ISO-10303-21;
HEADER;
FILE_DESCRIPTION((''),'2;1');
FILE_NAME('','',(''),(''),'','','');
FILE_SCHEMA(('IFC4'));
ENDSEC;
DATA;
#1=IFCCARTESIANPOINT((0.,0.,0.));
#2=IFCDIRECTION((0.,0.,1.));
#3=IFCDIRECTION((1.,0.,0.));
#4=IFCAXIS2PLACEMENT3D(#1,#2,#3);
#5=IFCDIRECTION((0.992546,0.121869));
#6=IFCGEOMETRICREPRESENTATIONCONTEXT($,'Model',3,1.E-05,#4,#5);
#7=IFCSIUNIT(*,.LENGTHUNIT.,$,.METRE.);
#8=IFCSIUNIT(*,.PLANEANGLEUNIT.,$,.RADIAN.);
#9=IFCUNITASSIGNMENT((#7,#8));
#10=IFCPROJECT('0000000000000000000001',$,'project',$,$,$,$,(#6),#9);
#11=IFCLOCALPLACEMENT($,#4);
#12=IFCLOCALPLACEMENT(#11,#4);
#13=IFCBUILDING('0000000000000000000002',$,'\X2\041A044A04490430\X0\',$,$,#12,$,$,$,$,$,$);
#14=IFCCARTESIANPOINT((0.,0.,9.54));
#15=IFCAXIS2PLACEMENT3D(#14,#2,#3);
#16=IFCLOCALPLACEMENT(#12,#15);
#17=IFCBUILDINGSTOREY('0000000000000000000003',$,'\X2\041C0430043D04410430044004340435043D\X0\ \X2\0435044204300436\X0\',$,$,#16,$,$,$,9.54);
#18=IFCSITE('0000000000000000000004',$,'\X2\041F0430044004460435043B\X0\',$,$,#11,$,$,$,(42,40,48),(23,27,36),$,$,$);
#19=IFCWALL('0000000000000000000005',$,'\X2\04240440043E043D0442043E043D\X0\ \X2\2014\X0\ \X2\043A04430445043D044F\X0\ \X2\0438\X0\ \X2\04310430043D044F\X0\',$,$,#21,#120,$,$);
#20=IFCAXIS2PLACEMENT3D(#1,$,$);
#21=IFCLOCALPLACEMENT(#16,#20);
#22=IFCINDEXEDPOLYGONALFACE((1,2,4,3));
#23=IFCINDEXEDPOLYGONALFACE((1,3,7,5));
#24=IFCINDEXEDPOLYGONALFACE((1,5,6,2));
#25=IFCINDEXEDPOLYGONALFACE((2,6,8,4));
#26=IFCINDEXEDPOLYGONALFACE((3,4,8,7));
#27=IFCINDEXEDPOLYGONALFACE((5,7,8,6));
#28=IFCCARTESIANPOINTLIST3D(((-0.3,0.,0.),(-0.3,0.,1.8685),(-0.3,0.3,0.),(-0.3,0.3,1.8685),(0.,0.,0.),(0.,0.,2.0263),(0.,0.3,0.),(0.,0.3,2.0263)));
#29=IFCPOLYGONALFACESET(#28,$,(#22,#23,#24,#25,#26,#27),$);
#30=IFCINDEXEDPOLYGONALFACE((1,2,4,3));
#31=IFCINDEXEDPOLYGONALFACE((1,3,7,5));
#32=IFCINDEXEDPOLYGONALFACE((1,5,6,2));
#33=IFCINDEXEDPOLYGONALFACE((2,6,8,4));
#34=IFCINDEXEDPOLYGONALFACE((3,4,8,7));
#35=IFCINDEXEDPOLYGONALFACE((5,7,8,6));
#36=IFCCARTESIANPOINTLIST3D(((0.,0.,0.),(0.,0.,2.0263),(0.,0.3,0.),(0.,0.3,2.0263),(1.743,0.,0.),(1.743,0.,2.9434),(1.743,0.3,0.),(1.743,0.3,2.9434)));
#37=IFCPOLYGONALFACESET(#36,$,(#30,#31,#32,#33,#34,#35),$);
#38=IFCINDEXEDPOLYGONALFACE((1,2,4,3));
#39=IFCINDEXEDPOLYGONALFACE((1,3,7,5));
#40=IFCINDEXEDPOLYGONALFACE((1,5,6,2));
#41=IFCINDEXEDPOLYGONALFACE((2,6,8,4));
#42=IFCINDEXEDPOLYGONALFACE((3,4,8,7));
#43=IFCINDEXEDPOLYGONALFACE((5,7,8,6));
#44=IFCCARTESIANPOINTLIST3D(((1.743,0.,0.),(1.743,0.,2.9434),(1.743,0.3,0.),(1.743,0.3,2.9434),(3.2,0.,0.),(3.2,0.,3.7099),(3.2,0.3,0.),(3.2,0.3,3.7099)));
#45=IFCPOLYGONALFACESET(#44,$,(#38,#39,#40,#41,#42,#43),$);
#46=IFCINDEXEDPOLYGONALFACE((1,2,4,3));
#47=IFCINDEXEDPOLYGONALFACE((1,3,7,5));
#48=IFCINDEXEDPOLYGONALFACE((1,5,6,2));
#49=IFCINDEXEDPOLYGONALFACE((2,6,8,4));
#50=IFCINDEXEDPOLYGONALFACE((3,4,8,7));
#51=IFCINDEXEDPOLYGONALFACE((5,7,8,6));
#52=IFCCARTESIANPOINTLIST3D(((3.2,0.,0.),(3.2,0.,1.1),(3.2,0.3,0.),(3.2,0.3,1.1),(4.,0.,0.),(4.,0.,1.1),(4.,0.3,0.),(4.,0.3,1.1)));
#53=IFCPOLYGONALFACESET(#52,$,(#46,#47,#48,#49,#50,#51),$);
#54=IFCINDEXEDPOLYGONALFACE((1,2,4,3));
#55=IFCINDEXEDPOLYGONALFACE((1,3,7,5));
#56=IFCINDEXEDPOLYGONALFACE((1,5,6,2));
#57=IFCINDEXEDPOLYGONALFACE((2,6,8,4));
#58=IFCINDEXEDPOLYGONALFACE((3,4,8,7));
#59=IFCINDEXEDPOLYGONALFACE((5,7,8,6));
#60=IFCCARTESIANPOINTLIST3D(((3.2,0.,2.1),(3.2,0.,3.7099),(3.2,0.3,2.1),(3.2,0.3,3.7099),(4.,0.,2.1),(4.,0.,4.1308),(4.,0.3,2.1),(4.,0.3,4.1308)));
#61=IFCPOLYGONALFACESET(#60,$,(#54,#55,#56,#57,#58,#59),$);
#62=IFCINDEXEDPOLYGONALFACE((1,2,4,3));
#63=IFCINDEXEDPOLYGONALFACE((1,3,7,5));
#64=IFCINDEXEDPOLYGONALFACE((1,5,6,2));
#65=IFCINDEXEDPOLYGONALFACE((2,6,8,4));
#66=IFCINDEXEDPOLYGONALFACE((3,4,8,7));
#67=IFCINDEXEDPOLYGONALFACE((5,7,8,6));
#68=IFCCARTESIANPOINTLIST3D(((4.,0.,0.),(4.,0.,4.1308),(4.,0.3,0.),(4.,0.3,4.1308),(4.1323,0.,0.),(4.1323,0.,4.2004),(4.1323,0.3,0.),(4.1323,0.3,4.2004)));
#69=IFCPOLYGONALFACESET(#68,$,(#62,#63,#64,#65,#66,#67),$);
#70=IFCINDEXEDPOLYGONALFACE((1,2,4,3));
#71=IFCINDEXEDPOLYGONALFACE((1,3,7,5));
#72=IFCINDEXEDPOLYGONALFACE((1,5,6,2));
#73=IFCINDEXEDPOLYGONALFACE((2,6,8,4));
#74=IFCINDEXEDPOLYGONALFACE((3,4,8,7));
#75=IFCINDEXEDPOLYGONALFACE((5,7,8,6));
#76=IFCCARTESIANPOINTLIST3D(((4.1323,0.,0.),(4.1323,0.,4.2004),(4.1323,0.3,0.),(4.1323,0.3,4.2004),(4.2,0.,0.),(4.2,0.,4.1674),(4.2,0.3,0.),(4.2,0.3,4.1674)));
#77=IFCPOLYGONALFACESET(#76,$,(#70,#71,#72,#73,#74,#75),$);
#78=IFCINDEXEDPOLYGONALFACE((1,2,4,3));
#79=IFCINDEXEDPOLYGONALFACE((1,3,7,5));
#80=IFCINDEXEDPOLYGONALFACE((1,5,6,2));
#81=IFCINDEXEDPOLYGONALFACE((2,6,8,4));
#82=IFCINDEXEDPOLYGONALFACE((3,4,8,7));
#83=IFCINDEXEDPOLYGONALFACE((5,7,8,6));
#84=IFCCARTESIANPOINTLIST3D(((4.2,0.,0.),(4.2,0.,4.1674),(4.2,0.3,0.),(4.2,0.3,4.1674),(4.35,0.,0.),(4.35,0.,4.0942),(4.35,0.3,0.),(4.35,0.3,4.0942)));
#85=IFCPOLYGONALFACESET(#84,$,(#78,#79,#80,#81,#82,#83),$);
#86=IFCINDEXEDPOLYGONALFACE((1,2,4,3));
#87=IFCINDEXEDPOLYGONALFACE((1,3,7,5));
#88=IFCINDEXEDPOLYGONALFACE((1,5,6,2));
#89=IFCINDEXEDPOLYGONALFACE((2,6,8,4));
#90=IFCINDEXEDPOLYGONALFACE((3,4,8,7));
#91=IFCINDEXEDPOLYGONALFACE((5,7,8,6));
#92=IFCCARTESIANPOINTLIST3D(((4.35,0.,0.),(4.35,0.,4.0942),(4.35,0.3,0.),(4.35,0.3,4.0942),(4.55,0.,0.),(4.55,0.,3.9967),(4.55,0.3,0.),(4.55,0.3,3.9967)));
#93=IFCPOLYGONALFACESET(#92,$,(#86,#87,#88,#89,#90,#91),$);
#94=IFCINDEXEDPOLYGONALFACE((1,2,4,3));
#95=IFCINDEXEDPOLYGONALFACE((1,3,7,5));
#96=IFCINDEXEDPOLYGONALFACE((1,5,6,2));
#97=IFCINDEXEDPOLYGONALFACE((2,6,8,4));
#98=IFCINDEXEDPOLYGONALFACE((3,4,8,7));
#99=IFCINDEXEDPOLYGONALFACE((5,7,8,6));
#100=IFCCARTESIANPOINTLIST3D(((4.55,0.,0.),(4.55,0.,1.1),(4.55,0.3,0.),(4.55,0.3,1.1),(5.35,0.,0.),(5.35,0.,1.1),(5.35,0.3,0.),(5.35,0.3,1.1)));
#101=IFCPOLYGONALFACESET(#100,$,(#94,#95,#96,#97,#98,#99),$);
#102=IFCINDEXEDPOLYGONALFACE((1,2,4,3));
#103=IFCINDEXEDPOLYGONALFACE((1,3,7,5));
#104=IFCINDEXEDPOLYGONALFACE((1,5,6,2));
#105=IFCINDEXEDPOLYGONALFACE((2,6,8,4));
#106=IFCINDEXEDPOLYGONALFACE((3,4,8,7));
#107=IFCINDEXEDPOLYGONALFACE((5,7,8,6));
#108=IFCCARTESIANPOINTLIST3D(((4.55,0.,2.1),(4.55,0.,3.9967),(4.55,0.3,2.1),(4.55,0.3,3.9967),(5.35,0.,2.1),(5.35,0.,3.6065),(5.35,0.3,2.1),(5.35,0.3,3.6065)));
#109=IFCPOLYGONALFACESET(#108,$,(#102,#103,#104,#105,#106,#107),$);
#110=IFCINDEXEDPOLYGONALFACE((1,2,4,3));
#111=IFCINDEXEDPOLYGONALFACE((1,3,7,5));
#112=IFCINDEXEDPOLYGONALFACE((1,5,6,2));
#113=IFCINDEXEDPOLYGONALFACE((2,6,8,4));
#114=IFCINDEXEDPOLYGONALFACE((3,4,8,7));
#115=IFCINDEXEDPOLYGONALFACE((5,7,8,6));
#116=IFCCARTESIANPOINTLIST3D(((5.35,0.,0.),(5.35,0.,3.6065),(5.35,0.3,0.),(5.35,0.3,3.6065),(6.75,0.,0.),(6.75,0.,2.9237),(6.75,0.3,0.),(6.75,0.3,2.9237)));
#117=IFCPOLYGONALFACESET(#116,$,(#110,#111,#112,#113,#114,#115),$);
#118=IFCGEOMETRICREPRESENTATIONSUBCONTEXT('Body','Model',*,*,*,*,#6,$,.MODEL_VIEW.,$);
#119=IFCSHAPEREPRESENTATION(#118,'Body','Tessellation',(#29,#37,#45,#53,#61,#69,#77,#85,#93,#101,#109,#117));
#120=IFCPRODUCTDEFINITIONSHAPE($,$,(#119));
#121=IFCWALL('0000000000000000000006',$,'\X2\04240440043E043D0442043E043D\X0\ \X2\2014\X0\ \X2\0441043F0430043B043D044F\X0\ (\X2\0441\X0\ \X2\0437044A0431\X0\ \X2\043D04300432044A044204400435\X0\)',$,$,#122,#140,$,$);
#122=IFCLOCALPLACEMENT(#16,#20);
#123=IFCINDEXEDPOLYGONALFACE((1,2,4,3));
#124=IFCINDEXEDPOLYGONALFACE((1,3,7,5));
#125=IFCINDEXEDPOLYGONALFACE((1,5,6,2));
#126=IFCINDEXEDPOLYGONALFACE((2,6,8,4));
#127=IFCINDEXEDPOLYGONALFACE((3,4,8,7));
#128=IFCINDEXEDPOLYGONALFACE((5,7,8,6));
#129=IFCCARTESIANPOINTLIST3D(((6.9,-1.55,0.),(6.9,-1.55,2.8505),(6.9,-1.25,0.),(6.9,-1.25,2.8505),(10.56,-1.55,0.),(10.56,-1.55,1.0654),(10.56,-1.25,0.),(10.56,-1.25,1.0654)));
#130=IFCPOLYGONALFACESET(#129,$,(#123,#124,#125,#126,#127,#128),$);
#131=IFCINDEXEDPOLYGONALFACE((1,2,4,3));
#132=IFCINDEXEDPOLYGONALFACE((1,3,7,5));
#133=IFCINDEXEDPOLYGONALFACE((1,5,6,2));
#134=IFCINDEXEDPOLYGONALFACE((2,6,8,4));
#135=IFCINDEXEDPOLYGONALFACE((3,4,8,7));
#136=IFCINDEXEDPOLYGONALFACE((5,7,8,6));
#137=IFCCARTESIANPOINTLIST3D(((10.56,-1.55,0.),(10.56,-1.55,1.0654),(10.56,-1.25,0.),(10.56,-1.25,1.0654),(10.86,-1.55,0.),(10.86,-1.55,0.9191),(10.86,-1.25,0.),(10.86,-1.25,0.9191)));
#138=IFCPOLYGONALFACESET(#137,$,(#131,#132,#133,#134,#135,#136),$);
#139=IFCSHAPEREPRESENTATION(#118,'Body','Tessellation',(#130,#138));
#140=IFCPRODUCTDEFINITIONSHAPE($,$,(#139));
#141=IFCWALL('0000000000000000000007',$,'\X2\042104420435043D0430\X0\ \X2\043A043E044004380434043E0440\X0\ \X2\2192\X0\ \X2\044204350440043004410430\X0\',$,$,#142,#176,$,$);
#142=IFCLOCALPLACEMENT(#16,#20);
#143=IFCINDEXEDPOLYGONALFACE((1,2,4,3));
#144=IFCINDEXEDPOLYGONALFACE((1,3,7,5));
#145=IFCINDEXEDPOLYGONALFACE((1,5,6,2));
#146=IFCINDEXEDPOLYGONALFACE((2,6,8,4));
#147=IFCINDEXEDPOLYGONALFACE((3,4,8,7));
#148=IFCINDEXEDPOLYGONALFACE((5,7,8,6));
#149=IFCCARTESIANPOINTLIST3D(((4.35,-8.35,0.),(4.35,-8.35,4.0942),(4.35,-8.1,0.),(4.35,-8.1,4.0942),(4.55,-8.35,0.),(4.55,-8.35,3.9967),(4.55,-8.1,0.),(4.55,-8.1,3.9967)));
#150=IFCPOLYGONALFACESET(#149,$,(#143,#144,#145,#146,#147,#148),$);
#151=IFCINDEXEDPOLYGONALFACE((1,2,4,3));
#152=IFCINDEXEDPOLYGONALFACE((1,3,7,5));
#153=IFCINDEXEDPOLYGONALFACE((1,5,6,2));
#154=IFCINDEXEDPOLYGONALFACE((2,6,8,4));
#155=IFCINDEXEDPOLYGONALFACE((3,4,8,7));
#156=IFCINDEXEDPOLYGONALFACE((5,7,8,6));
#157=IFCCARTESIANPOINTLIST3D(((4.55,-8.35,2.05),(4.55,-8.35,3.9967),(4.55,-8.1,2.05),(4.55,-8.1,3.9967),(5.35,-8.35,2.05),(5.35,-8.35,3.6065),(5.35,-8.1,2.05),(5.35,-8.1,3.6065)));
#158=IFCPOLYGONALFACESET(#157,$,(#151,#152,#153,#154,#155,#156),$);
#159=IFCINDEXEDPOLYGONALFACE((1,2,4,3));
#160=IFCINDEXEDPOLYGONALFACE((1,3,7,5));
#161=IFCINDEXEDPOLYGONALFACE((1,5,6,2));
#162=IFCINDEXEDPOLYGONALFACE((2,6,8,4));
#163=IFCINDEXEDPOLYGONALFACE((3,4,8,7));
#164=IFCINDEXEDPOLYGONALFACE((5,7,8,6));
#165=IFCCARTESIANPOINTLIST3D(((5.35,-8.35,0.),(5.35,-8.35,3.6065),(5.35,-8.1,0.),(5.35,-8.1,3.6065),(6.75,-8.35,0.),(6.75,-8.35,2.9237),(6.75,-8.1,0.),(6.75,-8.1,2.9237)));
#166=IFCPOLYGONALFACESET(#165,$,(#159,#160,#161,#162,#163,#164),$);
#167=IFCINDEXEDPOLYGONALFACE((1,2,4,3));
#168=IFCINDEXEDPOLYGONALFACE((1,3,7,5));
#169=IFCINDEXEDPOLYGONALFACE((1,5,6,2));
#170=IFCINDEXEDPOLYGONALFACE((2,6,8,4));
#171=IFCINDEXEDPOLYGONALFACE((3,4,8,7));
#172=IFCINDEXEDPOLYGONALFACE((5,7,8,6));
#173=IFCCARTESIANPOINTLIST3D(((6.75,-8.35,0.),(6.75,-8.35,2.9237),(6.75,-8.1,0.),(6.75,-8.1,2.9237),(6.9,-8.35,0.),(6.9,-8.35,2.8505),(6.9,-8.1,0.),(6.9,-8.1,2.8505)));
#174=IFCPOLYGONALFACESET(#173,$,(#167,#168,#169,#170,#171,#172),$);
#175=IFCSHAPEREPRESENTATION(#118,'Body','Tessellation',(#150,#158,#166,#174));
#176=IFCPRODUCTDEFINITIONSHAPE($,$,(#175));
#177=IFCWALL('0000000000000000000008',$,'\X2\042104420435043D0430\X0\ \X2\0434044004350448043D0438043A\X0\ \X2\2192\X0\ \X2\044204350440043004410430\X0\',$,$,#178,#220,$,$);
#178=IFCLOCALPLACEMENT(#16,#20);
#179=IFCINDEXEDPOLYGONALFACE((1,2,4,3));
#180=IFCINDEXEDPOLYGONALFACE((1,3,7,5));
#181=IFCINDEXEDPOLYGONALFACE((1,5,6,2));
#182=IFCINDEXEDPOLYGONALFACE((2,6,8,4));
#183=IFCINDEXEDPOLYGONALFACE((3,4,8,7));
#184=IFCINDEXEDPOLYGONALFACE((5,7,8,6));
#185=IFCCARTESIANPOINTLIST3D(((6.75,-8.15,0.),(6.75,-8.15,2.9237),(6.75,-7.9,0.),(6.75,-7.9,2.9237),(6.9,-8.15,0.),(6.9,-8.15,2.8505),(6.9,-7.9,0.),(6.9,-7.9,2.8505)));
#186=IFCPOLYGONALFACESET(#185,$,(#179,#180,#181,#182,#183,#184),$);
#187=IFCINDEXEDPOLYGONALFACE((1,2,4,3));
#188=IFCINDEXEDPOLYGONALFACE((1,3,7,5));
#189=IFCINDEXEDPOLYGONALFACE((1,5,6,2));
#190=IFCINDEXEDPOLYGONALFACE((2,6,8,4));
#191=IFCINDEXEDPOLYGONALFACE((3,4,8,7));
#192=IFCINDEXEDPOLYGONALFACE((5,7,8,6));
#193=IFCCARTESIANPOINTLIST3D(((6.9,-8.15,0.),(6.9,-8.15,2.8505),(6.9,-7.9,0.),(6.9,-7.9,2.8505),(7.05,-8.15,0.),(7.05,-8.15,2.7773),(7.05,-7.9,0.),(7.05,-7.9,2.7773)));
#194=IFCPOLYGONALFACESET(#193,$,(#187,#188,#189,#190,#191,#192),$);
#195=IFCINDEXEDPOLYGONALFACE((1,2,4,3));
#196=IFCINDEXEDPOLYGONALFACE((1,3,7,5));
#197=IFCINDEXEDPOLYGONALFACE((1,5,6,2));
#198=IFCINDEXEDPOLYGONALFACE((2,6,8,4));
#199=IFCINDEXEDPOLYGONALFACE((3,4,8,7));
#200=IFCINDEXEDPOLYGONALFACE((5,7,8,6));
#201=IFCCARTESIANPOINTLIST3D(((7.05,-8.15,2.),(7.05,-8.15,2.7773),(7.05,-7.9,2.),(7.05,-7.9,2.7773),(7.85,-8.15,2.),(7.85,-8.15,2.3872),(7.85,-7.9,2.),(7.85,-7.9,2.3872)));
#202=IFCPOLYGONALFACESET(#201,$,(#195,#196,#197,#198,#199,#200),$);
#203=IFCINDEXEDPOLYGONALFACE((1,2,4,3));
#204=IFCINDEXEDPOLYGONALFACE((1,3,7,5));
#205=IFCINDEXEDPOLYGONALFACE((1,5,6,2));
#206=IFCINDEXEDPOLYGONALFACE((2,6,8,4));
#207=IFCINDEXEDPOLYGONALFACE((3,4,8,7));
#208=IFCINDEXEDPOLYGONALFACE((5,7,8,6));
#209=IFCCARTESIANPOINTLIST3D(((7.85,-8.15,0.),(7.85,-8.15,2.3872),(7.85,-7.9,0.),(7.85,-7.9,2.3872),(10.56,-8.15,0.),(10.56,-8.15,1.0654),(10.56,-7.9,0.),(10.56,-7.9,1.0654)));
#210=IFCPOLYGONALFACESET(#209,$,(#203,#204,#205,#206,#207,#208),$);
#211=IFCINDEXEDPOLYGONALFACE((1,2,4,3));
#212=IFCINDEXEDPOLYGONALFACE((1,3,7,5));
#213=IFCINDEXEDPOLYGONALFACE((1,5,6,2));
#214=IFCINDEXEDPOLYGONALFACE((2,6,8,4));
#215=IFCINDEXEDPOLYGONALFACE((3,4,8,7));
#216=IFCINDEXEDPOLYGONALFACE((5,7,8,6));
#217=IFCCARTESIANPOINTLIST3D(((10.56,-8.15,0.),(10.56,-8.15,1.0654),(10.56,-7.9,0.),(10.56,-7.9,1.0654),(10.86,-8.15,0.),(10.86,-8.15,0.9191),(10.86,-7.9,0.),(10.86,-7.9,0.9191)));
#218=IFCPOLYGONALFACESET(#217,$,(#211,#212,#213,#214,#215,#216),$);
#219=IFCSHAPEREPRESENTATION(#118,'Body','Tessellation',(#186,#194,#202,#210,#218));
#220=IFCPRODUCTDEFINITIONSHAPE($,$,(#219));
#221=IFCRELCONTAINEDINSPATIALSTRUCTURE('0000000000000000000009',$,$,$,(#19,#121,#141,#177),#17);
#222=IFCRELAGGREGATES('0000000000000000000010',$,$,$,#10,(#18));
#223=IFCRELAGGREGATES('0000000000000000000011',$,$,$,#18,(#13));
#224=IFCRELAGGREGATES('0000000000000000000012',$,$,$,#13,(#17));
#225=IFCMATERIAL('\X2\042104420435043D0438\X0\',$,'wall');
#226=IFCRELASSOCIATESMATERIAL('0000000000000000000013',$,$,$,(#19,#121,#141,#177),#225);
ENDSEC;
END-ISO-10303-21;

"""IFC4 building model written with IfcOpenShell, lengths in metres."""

from ifc_helpers import new_model, si_unit, direction, frame, origin_with_axes, place, context, subcontext, project, spatial, polyline, outline, extrude, material, element, save


model = new_model("IFC4")

# Units and contexts
model_context = context("Model", 3, precision=1e-05, world=origin_with_axes(), true_north=direction((0.992546, 0.121869)))
body_context = subcontext(model_context, "Body", "Model", "MODEL_VIEW")
ifc_project = project(units=[si_unit("LENGTHUNIT", "METRE"), si_unit("PLANEANGLEUNIT", "RADIAN")], contexts=[model_context])

# Site, building, storey
site_placement = place(None, origin_with_axes())
site = spatial("IfcSite", under=ifc_project, at=site_placement, Name="Парцел", RefLatitude=(42, 40, 48), RefLongitude=(23, 27, 36))
building_placement = place(site_placement, origin_with_axes())
building = spatial("IfcBuilding", under=site, at=building_placement, Name="Къща")
storey_placement = place(building_placement, frame((0.0, 0.0, 9.54), z_axis=(0.0, 0.0, 1.0), x_axis=(1.0, 0.0, 0.0)))
storey = spatial("IfcBuildingStorey", under=building, at=storey_placement, Name="Мансарден етаж", Elevation=9.54)

# Walls
ifc_material_1 = material(Name="Стени", Category="wall")
wall_1_placement = place(storey_placement, origin_with_axes())
element("IfcWall", 1, at=wall_1_placement, inside=storey, material=ifc_material_1, Name="Фронтон — кухня и баня", context=body_context, shape_type="SweptSolid", body=[
    extrude(outline(polyline([(-0.3, 0.0), (0.0, 0.0), (0.0, -2.0263), (-0.3, -1.8685), (-0.3, 0.0)])), frame((0.0, 0.0, 0.0), z_axis=(0.0, 1.0, 0.0), x_axis=(1.0, 0.0, 0.0)), (0.0, 0.0, 1.0), 0.3),
    extrude(outline(polyline([(0.0, 0.0), (1.743, 0.0), (1.743, -2.9434), (0.0, -2.0263), (0.0, 0.0)])), frame((0.0, 0.0, 0.0), z_axis=(0.0, 1.0, 0.0), x_axis=(1.0, 0.0, 0.0)), (0.0, 0.0, 1.0), 0.3),
    extrude(outline(polyline([(1.743, 0.0), (3.2, 0.0), (3.2, -3.7099), (1.743, -2.9434), (1.743, 0.0)])), frame((0.0, 0.0, 0.0), z_axis=(0.0, 1.0, 0.0), x_axis=(1.0, 0.0, 0.0)), (0.0, 0.0, 1.0), 0.3),
    extrude(outline(polyline([(3.2, 0.0), (4.0, 0.0), (4.0, -1.1), (3.2, -1.1), (3.2, 0.0)])), frame((0.0, 0.0, 0.0), z_axis=(0.0, 1.0, 0.0), x_axis=(1.0, 0.0, 0.0)), (0.0, 0.0, 1.0), 0.3),
    extrude(outline(polyline([(3.2, -2.1), (4.0, -2.1), (4.0, -4.1308), (3.2, -3.7099), (3.2, -2.1)])), frame((0.0, 0.0, 0.0), z_axis=(0.0, 1.0, 0.0), x_axis=(1.0, 0.0, 0.0)), (0.0, 0.0, 1.0), 0.3),
    extrude(outline(polyline([(4.0, 0.0), (4.1323, 0.0), (4.1323, -4.2004), (4.0, -4.1308), (4.0, 0.0)])), frame((0.0, 0.0, 0.0), z_axis=(0.0, 1.0, 0.0), x_axis=(1.0, 0.0, 0.0)), (0.0, 0.0, 1.0), 0.3),
    extrude(outline(polyline([(4.1323, 0.0), (4.2, 0.0), (4.2, -4.1674), (4.1323, -4.2004), (4.1323, 0.0)])), frame((0.0, 0.0, 0.0), z_axis=(0.0, 1.0, 0.0), x_axis=(1.0, 0.0, 0.0)), (0.0, 0.0, 1.0), 0.3),
    extrude(outline(polyline([(4.2, 0.0), (4.35, 0.0), (4.35, -4.0942), (4.2, -4.1674), (4.2, 0.0)])), frame((0.0, 0.0, 0.0), z_axis=(0.0, 1.0, 0.0), x_axis=(1.0, 0.0, 0.0)), (0.0, 0.0, 1.0), 0.3),
    extrude(outline(polyline([(4.35, 0.0), (4.55, 0.0), (4.55, -3.9967), (4.35, -4.0942), (4.35, 0.0)])), frame((0.0, 0.0, 0.0), z_axis=(0.0, 1.0, 0.0), x_axis=(1.0, 0.0, 0.0)), (0.0, 0.0, 1.0), 0.3),
    extrude(outline(polyline([(4.55, 0.0), (5.35, 0.0), (5.35, -1.1), (4.55, -1.1), (4.55, 0.0)])), frame((0.0, 0.0, 0.0), z_axis=(0.0, 1.0, 0.0), x_axis=(1.0, 0.0, 0.0)), (0.0, 0.0, 1.0), 0.3),
    extrude(outline(polyline([(4.55, -2.1), (5.35, -2.1), (5.35, -3.6065), (4.55, -3.9967), (4.55, -2.1)])), frame((0.0, 0.0, 0.0), z_axis=(0.0, 1.0, 0.0), x_axis=(1.0, 0.0, 0.0)), (0.0, 0.0, 1.0), 0.3),
    extrude(outline(polyline([(5.35, 0.0), (6.75, 0.0), (6.75, -2.9237), (5.35, -3.6065), (5.35, 0.0)])), frame((0.0, 0.0, 0.0), z_axis=(0.0, 1.0, 0.0), x_axis=(1.0, 0.0, 0.0)), (0.0, 0.0, 1.0), 0.3),
])
wall_2_placement = place(storey_placement, origin_with_axes())
element("IfcWall", 2, at=wall_2_placement, inside=storey, material=ifc_material_1, Name="Фронтон — спалня (с зъб навътре)", context=body_context, shape_type="SweptSolid", body=[
    extrude(outline(polyline([(6.9, 0.0), (10.56, 0.0), (10.56, -1.0654), (6.9, -2.8505), (6.9, 0.0)])), frame((0.0, -1.55, 0.0), z_axis=(0.0, 1.0, 0.0), x_axis=(1.0, 0.0, 0.0)), (0.0, 0.0, 1.0), 0.3),
    extrude(outline(polyline([(10.56, 0.0), (10.86, 0.0), (10.86, -0.9191), (10.56, -1.0654), (10.56, 0.0)])), frame((0.0, -1.55, 0.0), z_axis=(0.0, 1.0, 0.0), x_axis=(1.0, 0.0, 0.0)), (0.0, 0.0, 1.0), 0.3),
])
wall_3_placement = place(storey_placement, origin_with_axes())
element("IfcWall", 3, at=wall_3_placement, inside=storey, material=ifc_material_1, Name="Стена коридор → тераса", context=body_context, shape_type="SweptSolid", body=[
    extrude(outline(polyline([(4.35, 0.0), (4.55, 0.0), (4.55, -3.9967), (4.35, -4.0942), (4.35, 0.0)])), frame((0.0, -8.35, 0.0), z_axis=(0.0, 1.0, 0.0), x_axis=(1.0, 0.0, 0.0)), (0.0, 0.0, 1.0), 0.25),
    extrude(outline(polyline([(4.55, -2.05), (5.35, -2.05), (5.35, -3.6065), (4.55, -3.9967), (4.55, -2.05)])), frame((0.0, -8.35, 0.0), z_axis=(0.0, 1.0, 0.0), x_axis=(1.0, 0.0, 0.0)), (0.0, 0.0, 1.0), 0.25),
    extrude(outline(polyline([(5.35, 0.0), (6.75, 0.0), (6.75, -2.9237), (5.35, -3.6065), (5.35, 0.0)])), frame((0.0, -8.35, 0.0), z_axis=(0.0, 1.0, 0.0), x_axis=(1.0, 0.0, 0.0)), (0.0, 0.0, 1.0), 0.25),
    extrude(outline(polyline([(6.75, 0.0), (6.9, 0.0), (6.9, -2.8505), (6.75, -2.9237), (6.75, 0.0)])), frame((0.0, -8.35, 0.0), z_axis=(0.0, 1.0, 0.0), x_axis=(1.0, 0.0, 0.0)), (0.0, 0.0, 1.0), 0.25),
])
wall_4_placement = place(storey_placement, origin_with_axes())
element("IfcWall", 4, at=wall_4_placement, inside=storey, material=ifc_material_1, Name="Стена дрешник → тераса", context=body_context, shape_type="SweptSolid", body=[
    extrude(outline(polyline([(6.75, 0.0), (6.9, 0.0), (6.9, -2.8505), (6.75, -2.9237), (6.75, 0.0)])), frame((0.0, -8.15, 0.0), z_axis=(0.0, 1.0, 0.0), x_axis=(1.0, 0.0, 0.0)), (0.0, 0.0, 1.0), 0.25),
    extrude(outline(polyline([(6.9, 0.0), (7.05, 0.0), (7.05, -2.7773), (6.9, -2.8505), (6.9, 0.0)])), frame((0.0, -8.15, 0.0), z_axis=(0.0, 1.0, 0.0), x_axis=(1.0, 0.0, 0.0)), (0.0, 0.0, 1.0), 0.25),
    extrude(outline(polyline([(7.05, -2.0), (7.85, -2.0), (7.85, -2.3872), (7.05, -2.7773), (7.05, -2.0)])), frame((0.0, -8.15, 0.0), z_axis=(0.0, 1.0, 0.0), x_axis=(1.0, 0.0, 0.0)), (0.0, 0.0, 1.0), 0.25),
    extrude(outline(polyline([(7.85, 0.0), (10.56, 0.0), (10.56, -1.0654), (7.85, -2.3872), (7.85, 0.0)])), frame((0.0, -8.15, 0.0), z_axis=(0.0, 1.0, 0.0), x_axis=(1.0, 0.0, 0.0)), (0.0, 0.0, 1.0), 0.25),
    extrude(outline(polyline([(10.56, 0.0), (10.86, 0.0), (10.86, -0.9191), (10.56, -1.0654), (10.56, 0.0)])), frame((0.0, -8.15, 0.0), z_axis=(0.0, 1.0, 0.0), x_axis=(1.0, 0.0, 0.0)), (0.0, 0.0, 1.0), 0.25),
])

save(model, "model.ifc")
